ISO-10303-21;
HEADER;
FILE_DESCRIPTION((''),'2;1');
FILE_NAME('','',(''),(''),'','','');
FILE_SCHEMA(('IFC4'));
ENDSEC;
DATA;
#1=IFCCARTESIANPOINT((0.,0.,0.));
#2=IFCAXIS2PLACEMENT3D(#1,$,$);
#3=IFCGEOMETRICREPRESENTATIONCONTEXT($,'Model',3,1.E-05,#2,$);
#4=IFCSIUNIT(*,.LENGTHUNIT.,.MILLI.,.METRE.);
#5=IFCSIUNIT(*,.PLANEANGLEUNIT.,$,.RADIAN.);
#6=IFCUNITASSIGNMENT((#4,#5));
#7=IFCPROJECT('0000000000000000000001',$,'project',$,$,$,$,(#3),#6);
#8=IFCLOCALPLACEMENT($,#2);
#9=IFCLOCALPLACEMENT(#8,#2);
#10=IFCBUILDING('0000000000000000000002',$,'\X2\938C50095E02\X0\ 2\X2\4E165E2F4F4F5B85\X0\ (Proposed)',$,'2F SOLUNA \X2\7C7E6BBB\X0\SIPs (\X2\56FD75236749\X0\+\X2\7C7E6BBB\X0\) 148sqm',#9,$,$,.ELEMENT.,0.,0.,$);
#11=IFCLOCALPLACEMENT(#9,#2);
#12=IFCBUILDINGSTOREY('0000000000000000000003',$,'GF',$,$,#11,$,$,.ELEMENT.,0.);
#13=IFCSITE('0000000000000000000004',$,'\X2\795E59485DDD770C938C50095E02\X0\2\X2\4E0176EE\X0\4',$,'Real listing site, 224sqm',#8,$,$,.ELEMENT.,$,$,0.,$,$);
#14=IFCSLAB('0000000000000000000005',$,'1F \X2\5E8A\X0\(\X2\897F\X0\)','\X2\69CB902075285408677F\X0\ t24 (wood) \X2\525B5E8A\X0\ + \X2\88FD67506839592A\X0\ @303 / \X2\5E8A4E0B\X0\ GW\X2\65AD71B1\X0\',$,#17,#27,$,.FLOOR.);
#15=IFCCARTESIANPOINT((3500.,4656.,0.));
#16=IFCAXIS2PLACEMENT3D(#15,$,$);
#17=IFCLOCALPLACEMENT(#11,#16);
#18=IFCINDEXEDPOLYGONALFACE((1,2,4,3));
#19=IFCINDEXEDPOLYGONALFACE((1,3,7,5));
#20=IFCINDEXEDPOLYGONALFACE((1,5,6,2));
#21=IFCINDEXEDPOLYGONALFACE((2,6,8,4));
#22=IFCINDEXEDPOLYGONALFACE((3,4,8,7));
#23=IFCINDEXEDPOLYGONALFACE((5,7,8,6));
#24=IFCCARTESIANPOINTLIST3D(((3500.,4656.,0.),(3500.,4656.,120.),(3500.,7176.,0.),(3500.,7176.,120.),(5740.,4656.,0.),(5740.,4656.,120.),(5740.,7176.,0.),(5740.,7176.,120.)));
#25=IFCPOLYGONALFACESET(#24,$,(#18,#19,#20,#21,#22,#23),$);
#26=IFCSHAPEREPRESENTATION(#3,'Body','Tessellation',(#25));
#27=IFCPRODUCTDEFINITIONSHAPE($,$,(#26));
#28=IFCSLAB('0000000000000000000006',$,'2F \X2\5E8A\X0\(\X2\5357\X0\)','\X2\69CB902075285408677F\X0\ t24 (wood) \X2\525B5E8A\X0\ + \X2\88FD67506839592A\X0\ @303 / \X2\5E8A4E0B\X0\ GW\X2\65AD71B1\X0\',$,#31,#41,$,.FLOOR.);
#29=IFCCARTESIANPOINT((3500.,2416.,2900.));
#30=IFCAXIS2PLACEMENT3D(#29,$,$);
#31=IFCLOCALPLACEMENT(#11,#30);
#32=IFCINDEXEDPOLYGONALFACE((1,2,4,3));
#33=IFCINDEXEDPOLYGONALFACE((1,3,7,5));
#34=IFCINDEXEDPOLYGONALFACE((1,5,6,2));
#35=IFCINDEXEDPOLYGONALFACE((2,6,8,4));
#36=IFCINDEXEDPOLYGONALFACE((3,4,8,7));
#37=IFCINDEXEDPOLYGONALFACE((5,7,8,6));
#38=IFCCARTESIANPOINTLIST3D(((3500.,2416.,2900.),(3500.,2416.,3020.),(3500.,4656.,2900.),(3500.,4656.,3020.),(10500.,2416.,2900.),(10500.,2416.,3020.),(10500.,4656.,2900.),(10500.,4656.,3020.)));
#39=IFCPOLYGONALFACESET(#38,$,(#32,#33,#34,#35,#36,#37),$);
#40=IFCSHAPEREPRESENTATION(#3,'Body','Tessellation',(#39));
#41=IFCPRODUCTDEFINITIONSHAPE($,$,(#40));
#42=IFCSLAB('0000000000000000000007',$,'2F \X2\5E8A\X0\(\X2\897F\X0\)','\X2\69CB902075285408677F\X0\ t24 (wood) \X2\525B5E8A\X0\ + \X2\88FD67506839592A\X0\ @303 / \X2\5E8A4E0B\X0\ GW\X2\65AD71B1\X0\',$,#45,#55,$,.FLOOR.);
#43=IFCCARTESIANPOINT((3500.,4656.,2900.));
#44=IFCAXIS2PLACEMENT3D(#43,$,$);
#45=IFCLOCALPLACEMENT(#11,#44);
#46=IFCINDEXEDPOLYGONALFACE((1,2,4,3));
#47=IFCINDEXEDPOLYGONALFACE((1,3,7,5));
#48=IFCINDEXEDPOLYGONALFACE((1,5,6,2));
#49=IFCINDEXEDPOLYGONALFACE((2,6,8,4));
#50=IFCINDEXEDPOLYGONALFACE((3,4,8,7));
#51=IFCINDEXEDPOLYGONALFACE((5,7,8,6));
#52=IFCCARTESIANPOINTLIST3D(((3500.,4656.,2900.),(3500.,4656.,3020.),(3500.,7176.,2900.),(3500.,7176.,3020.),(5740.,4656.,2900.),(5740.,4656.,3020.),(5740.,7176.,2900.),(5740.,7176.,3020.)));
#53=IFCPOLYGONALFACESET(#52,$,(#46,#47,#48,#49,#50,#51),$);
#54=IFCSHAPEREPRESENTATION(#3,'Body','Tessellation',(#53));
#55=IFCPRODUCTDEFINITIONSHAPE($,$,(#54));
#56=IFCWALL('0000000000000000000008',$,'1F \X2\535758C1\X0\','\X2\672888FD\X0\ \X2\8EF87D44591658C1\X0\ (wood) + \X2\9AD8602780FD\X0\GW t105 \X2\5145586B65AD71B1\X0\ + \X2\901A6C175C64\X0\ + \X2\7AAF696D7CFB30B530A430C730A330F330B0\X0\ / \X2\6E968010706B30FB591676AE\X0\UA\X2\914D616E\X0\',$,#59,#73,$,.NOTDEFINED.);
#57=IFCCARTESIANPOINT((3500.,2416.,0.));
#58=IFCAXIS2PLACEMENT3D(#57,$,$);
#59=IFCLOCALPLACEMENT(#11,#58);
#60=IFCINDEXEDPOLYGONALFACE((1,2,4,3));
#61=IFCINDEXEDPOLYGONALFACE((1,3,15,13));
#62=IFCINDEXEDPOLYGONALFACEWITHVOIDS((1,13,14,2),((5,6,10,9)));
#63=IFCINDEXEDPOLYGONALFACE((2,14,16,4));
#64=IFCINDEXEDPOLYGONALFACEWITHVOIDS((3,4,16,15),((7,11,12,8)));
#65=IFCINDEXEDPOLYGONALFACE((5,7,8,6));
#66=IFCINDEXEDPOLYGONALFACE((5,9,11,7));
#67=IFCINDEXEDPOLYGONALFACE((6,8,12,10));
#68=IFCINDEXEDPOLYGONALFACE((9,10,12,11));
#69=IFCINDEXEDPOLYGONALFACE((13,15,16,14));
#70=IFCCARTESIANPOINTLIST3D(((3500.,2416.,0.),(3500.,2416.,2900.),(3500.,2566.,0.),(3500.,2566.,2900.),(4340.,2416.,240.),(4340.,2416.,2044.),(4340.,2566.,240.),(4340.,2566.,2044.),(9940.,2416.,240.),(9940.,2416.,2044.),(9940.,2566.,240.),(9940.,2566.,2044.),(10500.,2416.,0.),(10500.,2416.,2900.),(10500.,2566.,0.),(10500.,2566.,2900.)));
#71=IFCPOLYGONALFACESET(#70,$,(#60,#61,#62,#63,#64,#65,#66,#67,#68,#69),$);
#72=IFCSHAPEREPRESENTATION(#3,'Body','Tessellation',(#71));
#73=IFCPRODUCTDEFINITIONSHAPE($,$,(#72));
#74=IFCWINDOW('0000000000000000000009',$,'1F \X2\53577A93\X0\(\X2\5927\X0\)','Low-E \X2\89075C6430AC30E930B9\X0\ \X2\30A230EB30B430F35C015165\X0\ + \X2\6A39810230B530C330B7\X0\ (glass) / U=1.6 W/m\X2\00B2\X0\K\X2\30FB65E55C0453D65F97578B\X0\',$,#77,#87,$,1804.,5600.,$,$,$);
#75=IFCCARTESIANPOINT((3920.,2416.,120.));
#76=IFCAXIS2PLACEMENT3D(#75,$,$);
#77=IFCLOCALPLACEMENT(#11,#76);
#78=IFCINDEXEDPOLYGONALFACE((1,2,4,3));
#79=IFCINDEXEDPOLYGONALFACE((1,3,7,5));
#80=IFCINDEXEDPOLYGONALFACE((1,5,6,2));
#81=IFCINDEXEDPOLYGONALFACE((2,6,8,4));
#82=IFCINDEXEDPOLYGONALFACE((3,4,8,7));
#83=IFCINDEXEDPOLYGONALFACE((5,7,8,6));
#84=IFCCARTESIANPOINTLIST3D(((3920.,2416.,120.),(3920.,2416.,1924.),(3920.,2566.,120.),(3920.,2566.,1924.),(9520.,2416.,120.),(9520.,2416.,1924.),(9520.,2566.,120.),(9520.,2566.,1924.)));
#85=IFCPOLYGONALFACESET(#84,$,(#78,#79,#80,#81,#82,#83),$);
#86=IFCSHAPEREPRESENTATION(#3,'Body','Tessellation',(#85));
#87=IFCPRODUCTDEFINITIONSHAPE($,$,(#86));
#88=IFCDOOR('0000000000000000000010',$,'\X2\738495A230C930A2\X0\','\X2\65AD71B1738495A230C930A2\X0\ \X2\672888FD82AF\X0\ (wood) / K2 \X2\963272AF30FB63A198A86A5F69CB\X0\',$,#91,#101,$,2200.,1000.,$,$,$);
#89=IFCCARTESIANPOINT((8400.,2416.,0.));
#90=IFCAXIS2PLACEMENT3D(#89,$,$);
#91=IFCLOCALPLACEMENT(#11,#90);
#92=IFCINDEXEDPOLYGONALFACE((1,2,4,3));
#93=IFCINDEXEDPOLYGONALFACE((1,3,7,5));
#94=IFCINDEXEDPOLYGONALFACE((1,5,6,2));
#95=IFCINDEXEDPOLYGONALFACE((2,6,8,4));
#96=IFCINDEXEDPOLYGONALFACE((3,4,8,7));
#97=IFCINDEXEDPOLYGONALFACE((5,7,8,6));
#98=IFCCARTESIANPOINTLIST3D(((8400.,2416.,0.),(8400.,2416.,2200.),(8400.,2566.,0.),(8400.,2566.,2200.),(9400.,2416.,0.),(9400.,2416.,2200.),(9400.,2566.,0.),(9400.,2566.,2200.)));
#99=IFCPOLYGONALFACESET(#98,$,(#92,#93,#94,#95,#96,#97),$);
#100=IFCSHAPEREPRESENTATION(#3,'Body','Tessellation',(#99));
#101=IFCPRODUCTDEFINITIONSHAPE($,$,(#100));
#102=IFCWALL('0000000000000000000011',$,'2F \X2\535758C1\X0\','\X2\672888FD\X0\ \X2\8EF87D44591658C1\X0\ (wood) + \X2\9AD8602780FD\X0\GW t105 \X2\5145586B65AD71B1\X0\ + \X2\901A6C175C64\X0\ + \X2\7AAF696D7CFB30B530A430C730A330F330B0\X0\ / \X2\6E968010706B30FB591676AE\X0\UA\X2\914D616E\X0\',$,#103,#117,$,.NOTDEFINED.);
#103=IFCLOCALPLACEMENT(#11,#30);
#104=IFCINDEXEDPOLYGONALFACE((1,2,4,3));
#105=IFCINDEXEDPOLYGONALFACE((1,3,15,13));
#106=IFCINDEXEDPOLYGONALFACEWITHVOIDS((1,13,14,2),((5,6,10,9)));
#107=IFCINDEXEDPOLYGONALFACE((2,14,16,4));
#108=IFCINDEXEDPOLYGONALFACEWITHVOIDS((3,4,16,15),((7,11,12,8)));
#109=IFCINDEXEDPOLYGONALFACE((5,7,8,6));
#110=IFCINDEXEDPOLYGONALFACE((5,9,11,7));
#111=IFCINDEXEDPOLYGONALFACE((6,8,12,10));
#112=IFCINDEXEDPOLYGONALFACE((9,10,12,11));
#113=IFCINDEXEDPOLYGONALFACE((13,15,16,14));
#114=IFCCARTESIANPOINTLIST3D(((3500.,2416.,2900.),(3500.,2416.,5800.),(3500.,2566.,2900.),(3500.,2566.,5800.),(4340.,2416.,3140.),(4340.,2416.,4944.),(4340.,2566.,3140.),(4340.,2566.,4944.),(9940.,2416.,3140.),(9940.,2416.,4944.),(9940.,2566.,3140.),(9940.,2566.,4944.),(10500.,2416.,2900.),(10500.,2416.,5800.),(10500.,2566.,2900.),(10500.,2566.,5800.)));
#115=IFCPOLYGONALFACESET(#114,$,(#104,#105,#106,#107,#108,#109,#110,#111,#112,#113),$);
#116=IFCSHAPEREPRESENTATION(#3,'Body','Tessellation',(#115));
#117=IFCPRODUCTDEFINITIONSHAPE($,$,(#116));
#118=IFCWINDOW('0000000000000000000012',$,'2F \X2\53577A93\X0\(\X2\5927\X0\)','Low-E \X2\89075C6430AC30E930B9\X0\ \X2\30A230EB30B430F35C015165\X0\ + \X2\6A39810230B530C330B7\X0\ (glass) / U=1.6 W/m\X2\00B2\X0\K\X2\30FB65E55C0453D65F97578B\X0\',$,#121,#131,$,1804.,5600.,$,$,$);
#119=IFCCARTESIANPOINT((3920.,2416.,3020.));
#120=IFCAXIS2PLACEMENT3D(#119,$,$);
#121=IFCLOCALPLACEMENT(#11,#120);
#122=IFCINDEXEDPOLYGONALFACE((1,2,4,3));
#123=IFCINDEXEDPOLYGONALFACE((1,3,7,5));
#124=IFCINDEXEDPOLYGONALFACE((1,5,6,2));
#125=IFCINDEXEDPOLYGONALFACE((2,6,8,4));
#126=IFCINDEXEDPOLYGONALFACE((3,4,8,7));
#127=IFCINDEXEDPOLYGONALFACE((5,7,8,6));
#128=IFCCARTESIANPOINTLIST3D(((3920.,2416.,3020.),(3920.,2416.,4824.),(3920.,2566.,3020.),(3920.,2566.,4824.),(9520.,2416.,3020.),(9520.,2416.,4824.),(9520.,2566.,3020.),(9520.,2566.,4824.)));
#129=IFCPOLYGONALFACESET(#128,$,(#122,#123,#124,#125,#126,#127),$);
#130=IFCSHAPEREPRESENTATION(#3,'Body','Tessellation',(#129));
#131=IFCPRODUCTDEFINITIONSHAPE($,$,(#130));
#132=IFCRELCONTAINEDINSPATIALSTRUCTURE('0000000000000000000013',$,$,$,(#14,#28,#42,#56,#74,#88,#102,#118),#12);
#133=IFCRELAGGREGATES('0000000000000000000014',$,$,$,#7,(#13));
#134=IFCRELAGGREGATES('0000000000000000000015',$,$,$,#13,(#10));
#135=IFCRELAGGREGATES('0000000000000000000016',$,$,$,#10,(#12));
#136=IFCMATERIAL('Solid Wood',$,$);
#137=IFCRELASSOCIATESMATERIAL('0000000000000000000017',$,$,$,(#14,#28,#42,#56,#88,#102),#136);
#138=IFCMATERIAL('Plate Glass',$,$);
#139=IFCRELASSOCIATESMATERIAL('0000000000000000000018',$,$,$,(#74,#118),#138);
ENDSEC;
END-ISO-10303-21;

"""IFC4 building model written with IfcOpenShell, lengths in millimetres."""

from ifc_helpers import new_model, si_unit, frame, frame_2d, origin, place, context, project, spatial, rectangle, extrude, material, element, fill, save


model = new_model("IFC4")

# Units and contexts
model_context = context("Model", 3, precision=1e-05, world=origin())
ifc_project = project(units=[si_unit("LENGTHUNIT", "METRE", prefix="MILLI"), si_unit("PLANEANGLEUNIT", "RADIAN")], contexts=[model_context])

# Site, building, storey
site_placement = place(None, origin())
site = spatial("IfcSite", under=ifc_project, at=site_placement, Name="神奈川県鎌倉市2丁目4", ObjectType="Real listing site, 224sqm", CompositionType="ELEMENT", RefElevation=0.0)
building_placement = place(site_placement, origin())
building = spatial("IfcBuilding", under=site, at=building_placement, Name="鎌倉市 2世帯住宅 (Proposed)", ObjectType="2F SOLUNA 籾殻SIPs (国産杉+籾殻) 148sqm", CompositionType="ELEMENT", ElevationOfRefHeight=0.0, ElevationOfTerrain=0.0)
storey_placement = place(building_placement, origin())
storey = spatial("IfcBuildingStorey", under=building, at=storey_placement, Name="GF", CompositionType="ELEMENT", Elevation=0.0)

# Slabs
ifc_material_1 = material(Name="Solid Wood")
slab_1_placement = place(storey_placement, frame((3500.0, 4656.0, 0.0)))
element("IfcSlab", 1, at=slab_1_placement, inside=storey, material=ifc_material_1, Name="1F 床(西)", Description="構造用合板 t24 (wood) 剛床 + 製材根太 @303 / 床下 GW断熱", PredefinedType="FLOOR", context=model_context, shape_type="SweptSolid", body=[
    extrude(rectangle(XDim=2240.0, YDim=2520.0, at=frame_2d((1120.0, 1260.0))), frame((3500.0, 4656.0, 0.0)), (0.0, 0.0, 1.0), 120.0),
])
slab_2_placement = place(storey_placement, frame((3500.0, 2416.0, 2900.0)))
element("IfcSlab", 2, at=slab_2_placement, inside=storey, material=ifc_material_1, Name="2F 床(南)", Description="構造用合板 t24 (wood) 剛床 + 製材根太 @303 / 床下 GW断熱", PredefinedType="FLOOR", context=model_context, shape_type="SweptSolid", body=[
    extrude(rectangle(XDim=7000.0, YDim=2240.0, at=frame_2d((3500.0, 1120.0))), frame((3500.0, 2416.0, 2900.0)), (0.0, 0.0, 1.0), 120.0),
])
slab_3_placement = place(storey_placement, frame((3500.0, 4656.0, 2900.0)))
element("IfcSlab", 3, at=slab_3_placement, inside=storey, material=ifc_material_1, Name="2F 床(西)", Description="構造用合板 t24 (wood) 剛床 + 製材根太 @303 / 床下 GW断熱", PredefinedType="FLOOR", context=model_context, shape_type="SweptSolid", body=[
    extrude(rectangle(XDim=2240.0, YDim=2520.0, at=frame_2d((1120.0, 1260.0))), frame((3500.0, 4656.0, 2900.0)), (0.0, 0.0, 1.0), 120.0),
])

# Wall, openings, window, door
wall_1_placement = place(storey_placement, frame((3500.0, 2416.0, 0.0)))
wall_1 = element("IfcWall", 4, at=wall_1_placement, inside=storey, material=ifc_material_1, Name="1F 南壁", Description="木製 軸組外壁 (wood) + 高性能GW t105 充填断熱 + 通気層 + 窯業系サイディング / 準耐火・外皮UA配慮", PredefinedType="NOTDEFINED", context=model_context, shape_type="SweptSolid", body=[
    extrude(rectangle(XDim=7000.0, YDim=150.0, at=frame_2d((3500.0, 75.0))), frame((3500.0, 2416.0, 0.0)), (0.0, 0.0, 1.0), 2900.0),
])
opening_1_placement = place(storey_placement, frame((3920.0, 2416.0, 120.0)))
opening_1 = element("IfcOpeningElement", 5, at=opening_1_placement, cuts=wall_1, PredefinedType="NOTDEFINED", context=model_context, shape_type="SweptSolid", body=[
    extrude(rectangle(XDim=5600.0, YDim=150.0, at=frame_2d((2800.0, 75.0))), frame((3920.0, 2416.0, 120.0)), (0.0, 0.0, 1.0), 1804.0),
])
opening_2_placement = place(storey_placement, frame((8400.0, 2416.0, 0.0)))
opening_2 = element("IfcOpeningElement", 6, at=opening_2_placement, cuts=wall_1, PredefinedType="NOTDEFINED", context=model_context, shape_type="SweptSolid", body=[
    extrude(rectangle(XDim=1000.0, YDim=150.0, at=frame_2d((500.0, 75.0))), frame((8400.0, 2416.0, 0.0)), (0.0, 0.0, 1.0), 2200.0),
])
ifc_material_2 = material(Name="Plate Glass")
window_1_placement = place(storey_placement, frame((3920.0, 2416.0, 120.0)))
window_1 = element("IfcWindow", 7, at=window_1_placement, inside=storey, material=ifc_material_2, Name="1F 南窓(大)", Description="Low-E 複層ガラス アルゴン封入 + 樹脂サッシ (glass) / U=1.6 W/m²K・日射取得型", OverallHeight=1804.0, OverallWidth=5600.0, context=model_context, shape_type="SweptSolid", body=[
    extrude(rectangle(XDim=5600.0, YDim=150.0, at=frame_2d((2800.0, 75.0))), frame((3920.0, 2416.0, 120.0)), (0.0, 0.0, 1.0), 1804.0),
])
fill(opening_1, window_1)
door_placement = place(storey_placement, frame((8400.0, 2416.0, 0.0)))
door = element("IfcDoor", 8, at=door_placement, inside=storey, material=ifc_material_1, Name="玄関ドア", Description="断熱玄関ドア 木製芯 (wood) / K2 防犯・採風機構", OverallHeight=2200.0, OverallWidth=1000.0, context=model_context, shape_type="SweptSolid", body=[
    extrude(rectangle(XDim=1000.0, YDim=150.0, at=frame_2d((500.0, 75.0))), frame((8400.0, 2416.0, 0.0)), (0.0, 0.0, 1.0), 2200.0),
])
fill(opening_2, door)

# Wall, opening, window
wall_2_placement = place(storey_placement, frame((3500.0, 2416.0, 2900.0)))
wall_2 = element("IfcWall", 9, at=wall_2_placement, inside=storey, material=ifc_material_1, Name="2F 南壁", Description="木製 軸組外壁 (wood) + 高性能GW t105 充填断熱 + 通気層 + 窯業系サイディング / 準耐火・外皮UA配慮", PredefinedType="NOTDEFINED", context=model_context, shape_type="SweptSolid", body=[
    extrude(rectangle(XDim=7000.0, YDim=150.0, at=frame_2d((3500.0, 75.0))), frame((3500.0, 2416.0, 2900.0)), (0.0, 0.0, 1.0), 2900.0),
])
opening_3_placement = place(storey_placement, frame((3920.0, 2416.0, 3020.0)))
opening_3 = element("IfcOpeningElement", 10, at=opening_3_placement, cuts=wall_2, PredefinedType="NOTDEFINED", context=model_context, shape_type="SweptSolid", body=[
    extrude(rectangle(XDim=5600.0, YDim=150.0, at=frame_2d((2800.0, 75.0))), frame((3920.0, 2416.0, 3020.0)), (0.0, 0.0, 1.0), 1804.0),
])
window_2_placement = place(storey_placement, frame((3920.0, 2416.0, 3020.0)))
window_2 = element("IfcWindow", 11, at=window_2_placement, inside=storey, material=ifc_material_2, Name="2F 南窓(大)", Description="Low-E 複層ガラス アルゴン封入 + 樹脂サッシ (glass) / U=1.6 W/m²K・日射取得型", OverallHeight=1804.0, OverallWidth=5600.0, context=model_context, shape_type="SweptSolid", body=[
    extrude(rectangle(XDim=5600.0, YDim=150.0, at=frame_2d((2800.0, 75.0))), frame((3920.0, 2416.0, 3020.0)), (0.0, 0.0, 1.0), 1804.0),
])
fill(opening_3, window_2)

save(model, "model.ifc")
